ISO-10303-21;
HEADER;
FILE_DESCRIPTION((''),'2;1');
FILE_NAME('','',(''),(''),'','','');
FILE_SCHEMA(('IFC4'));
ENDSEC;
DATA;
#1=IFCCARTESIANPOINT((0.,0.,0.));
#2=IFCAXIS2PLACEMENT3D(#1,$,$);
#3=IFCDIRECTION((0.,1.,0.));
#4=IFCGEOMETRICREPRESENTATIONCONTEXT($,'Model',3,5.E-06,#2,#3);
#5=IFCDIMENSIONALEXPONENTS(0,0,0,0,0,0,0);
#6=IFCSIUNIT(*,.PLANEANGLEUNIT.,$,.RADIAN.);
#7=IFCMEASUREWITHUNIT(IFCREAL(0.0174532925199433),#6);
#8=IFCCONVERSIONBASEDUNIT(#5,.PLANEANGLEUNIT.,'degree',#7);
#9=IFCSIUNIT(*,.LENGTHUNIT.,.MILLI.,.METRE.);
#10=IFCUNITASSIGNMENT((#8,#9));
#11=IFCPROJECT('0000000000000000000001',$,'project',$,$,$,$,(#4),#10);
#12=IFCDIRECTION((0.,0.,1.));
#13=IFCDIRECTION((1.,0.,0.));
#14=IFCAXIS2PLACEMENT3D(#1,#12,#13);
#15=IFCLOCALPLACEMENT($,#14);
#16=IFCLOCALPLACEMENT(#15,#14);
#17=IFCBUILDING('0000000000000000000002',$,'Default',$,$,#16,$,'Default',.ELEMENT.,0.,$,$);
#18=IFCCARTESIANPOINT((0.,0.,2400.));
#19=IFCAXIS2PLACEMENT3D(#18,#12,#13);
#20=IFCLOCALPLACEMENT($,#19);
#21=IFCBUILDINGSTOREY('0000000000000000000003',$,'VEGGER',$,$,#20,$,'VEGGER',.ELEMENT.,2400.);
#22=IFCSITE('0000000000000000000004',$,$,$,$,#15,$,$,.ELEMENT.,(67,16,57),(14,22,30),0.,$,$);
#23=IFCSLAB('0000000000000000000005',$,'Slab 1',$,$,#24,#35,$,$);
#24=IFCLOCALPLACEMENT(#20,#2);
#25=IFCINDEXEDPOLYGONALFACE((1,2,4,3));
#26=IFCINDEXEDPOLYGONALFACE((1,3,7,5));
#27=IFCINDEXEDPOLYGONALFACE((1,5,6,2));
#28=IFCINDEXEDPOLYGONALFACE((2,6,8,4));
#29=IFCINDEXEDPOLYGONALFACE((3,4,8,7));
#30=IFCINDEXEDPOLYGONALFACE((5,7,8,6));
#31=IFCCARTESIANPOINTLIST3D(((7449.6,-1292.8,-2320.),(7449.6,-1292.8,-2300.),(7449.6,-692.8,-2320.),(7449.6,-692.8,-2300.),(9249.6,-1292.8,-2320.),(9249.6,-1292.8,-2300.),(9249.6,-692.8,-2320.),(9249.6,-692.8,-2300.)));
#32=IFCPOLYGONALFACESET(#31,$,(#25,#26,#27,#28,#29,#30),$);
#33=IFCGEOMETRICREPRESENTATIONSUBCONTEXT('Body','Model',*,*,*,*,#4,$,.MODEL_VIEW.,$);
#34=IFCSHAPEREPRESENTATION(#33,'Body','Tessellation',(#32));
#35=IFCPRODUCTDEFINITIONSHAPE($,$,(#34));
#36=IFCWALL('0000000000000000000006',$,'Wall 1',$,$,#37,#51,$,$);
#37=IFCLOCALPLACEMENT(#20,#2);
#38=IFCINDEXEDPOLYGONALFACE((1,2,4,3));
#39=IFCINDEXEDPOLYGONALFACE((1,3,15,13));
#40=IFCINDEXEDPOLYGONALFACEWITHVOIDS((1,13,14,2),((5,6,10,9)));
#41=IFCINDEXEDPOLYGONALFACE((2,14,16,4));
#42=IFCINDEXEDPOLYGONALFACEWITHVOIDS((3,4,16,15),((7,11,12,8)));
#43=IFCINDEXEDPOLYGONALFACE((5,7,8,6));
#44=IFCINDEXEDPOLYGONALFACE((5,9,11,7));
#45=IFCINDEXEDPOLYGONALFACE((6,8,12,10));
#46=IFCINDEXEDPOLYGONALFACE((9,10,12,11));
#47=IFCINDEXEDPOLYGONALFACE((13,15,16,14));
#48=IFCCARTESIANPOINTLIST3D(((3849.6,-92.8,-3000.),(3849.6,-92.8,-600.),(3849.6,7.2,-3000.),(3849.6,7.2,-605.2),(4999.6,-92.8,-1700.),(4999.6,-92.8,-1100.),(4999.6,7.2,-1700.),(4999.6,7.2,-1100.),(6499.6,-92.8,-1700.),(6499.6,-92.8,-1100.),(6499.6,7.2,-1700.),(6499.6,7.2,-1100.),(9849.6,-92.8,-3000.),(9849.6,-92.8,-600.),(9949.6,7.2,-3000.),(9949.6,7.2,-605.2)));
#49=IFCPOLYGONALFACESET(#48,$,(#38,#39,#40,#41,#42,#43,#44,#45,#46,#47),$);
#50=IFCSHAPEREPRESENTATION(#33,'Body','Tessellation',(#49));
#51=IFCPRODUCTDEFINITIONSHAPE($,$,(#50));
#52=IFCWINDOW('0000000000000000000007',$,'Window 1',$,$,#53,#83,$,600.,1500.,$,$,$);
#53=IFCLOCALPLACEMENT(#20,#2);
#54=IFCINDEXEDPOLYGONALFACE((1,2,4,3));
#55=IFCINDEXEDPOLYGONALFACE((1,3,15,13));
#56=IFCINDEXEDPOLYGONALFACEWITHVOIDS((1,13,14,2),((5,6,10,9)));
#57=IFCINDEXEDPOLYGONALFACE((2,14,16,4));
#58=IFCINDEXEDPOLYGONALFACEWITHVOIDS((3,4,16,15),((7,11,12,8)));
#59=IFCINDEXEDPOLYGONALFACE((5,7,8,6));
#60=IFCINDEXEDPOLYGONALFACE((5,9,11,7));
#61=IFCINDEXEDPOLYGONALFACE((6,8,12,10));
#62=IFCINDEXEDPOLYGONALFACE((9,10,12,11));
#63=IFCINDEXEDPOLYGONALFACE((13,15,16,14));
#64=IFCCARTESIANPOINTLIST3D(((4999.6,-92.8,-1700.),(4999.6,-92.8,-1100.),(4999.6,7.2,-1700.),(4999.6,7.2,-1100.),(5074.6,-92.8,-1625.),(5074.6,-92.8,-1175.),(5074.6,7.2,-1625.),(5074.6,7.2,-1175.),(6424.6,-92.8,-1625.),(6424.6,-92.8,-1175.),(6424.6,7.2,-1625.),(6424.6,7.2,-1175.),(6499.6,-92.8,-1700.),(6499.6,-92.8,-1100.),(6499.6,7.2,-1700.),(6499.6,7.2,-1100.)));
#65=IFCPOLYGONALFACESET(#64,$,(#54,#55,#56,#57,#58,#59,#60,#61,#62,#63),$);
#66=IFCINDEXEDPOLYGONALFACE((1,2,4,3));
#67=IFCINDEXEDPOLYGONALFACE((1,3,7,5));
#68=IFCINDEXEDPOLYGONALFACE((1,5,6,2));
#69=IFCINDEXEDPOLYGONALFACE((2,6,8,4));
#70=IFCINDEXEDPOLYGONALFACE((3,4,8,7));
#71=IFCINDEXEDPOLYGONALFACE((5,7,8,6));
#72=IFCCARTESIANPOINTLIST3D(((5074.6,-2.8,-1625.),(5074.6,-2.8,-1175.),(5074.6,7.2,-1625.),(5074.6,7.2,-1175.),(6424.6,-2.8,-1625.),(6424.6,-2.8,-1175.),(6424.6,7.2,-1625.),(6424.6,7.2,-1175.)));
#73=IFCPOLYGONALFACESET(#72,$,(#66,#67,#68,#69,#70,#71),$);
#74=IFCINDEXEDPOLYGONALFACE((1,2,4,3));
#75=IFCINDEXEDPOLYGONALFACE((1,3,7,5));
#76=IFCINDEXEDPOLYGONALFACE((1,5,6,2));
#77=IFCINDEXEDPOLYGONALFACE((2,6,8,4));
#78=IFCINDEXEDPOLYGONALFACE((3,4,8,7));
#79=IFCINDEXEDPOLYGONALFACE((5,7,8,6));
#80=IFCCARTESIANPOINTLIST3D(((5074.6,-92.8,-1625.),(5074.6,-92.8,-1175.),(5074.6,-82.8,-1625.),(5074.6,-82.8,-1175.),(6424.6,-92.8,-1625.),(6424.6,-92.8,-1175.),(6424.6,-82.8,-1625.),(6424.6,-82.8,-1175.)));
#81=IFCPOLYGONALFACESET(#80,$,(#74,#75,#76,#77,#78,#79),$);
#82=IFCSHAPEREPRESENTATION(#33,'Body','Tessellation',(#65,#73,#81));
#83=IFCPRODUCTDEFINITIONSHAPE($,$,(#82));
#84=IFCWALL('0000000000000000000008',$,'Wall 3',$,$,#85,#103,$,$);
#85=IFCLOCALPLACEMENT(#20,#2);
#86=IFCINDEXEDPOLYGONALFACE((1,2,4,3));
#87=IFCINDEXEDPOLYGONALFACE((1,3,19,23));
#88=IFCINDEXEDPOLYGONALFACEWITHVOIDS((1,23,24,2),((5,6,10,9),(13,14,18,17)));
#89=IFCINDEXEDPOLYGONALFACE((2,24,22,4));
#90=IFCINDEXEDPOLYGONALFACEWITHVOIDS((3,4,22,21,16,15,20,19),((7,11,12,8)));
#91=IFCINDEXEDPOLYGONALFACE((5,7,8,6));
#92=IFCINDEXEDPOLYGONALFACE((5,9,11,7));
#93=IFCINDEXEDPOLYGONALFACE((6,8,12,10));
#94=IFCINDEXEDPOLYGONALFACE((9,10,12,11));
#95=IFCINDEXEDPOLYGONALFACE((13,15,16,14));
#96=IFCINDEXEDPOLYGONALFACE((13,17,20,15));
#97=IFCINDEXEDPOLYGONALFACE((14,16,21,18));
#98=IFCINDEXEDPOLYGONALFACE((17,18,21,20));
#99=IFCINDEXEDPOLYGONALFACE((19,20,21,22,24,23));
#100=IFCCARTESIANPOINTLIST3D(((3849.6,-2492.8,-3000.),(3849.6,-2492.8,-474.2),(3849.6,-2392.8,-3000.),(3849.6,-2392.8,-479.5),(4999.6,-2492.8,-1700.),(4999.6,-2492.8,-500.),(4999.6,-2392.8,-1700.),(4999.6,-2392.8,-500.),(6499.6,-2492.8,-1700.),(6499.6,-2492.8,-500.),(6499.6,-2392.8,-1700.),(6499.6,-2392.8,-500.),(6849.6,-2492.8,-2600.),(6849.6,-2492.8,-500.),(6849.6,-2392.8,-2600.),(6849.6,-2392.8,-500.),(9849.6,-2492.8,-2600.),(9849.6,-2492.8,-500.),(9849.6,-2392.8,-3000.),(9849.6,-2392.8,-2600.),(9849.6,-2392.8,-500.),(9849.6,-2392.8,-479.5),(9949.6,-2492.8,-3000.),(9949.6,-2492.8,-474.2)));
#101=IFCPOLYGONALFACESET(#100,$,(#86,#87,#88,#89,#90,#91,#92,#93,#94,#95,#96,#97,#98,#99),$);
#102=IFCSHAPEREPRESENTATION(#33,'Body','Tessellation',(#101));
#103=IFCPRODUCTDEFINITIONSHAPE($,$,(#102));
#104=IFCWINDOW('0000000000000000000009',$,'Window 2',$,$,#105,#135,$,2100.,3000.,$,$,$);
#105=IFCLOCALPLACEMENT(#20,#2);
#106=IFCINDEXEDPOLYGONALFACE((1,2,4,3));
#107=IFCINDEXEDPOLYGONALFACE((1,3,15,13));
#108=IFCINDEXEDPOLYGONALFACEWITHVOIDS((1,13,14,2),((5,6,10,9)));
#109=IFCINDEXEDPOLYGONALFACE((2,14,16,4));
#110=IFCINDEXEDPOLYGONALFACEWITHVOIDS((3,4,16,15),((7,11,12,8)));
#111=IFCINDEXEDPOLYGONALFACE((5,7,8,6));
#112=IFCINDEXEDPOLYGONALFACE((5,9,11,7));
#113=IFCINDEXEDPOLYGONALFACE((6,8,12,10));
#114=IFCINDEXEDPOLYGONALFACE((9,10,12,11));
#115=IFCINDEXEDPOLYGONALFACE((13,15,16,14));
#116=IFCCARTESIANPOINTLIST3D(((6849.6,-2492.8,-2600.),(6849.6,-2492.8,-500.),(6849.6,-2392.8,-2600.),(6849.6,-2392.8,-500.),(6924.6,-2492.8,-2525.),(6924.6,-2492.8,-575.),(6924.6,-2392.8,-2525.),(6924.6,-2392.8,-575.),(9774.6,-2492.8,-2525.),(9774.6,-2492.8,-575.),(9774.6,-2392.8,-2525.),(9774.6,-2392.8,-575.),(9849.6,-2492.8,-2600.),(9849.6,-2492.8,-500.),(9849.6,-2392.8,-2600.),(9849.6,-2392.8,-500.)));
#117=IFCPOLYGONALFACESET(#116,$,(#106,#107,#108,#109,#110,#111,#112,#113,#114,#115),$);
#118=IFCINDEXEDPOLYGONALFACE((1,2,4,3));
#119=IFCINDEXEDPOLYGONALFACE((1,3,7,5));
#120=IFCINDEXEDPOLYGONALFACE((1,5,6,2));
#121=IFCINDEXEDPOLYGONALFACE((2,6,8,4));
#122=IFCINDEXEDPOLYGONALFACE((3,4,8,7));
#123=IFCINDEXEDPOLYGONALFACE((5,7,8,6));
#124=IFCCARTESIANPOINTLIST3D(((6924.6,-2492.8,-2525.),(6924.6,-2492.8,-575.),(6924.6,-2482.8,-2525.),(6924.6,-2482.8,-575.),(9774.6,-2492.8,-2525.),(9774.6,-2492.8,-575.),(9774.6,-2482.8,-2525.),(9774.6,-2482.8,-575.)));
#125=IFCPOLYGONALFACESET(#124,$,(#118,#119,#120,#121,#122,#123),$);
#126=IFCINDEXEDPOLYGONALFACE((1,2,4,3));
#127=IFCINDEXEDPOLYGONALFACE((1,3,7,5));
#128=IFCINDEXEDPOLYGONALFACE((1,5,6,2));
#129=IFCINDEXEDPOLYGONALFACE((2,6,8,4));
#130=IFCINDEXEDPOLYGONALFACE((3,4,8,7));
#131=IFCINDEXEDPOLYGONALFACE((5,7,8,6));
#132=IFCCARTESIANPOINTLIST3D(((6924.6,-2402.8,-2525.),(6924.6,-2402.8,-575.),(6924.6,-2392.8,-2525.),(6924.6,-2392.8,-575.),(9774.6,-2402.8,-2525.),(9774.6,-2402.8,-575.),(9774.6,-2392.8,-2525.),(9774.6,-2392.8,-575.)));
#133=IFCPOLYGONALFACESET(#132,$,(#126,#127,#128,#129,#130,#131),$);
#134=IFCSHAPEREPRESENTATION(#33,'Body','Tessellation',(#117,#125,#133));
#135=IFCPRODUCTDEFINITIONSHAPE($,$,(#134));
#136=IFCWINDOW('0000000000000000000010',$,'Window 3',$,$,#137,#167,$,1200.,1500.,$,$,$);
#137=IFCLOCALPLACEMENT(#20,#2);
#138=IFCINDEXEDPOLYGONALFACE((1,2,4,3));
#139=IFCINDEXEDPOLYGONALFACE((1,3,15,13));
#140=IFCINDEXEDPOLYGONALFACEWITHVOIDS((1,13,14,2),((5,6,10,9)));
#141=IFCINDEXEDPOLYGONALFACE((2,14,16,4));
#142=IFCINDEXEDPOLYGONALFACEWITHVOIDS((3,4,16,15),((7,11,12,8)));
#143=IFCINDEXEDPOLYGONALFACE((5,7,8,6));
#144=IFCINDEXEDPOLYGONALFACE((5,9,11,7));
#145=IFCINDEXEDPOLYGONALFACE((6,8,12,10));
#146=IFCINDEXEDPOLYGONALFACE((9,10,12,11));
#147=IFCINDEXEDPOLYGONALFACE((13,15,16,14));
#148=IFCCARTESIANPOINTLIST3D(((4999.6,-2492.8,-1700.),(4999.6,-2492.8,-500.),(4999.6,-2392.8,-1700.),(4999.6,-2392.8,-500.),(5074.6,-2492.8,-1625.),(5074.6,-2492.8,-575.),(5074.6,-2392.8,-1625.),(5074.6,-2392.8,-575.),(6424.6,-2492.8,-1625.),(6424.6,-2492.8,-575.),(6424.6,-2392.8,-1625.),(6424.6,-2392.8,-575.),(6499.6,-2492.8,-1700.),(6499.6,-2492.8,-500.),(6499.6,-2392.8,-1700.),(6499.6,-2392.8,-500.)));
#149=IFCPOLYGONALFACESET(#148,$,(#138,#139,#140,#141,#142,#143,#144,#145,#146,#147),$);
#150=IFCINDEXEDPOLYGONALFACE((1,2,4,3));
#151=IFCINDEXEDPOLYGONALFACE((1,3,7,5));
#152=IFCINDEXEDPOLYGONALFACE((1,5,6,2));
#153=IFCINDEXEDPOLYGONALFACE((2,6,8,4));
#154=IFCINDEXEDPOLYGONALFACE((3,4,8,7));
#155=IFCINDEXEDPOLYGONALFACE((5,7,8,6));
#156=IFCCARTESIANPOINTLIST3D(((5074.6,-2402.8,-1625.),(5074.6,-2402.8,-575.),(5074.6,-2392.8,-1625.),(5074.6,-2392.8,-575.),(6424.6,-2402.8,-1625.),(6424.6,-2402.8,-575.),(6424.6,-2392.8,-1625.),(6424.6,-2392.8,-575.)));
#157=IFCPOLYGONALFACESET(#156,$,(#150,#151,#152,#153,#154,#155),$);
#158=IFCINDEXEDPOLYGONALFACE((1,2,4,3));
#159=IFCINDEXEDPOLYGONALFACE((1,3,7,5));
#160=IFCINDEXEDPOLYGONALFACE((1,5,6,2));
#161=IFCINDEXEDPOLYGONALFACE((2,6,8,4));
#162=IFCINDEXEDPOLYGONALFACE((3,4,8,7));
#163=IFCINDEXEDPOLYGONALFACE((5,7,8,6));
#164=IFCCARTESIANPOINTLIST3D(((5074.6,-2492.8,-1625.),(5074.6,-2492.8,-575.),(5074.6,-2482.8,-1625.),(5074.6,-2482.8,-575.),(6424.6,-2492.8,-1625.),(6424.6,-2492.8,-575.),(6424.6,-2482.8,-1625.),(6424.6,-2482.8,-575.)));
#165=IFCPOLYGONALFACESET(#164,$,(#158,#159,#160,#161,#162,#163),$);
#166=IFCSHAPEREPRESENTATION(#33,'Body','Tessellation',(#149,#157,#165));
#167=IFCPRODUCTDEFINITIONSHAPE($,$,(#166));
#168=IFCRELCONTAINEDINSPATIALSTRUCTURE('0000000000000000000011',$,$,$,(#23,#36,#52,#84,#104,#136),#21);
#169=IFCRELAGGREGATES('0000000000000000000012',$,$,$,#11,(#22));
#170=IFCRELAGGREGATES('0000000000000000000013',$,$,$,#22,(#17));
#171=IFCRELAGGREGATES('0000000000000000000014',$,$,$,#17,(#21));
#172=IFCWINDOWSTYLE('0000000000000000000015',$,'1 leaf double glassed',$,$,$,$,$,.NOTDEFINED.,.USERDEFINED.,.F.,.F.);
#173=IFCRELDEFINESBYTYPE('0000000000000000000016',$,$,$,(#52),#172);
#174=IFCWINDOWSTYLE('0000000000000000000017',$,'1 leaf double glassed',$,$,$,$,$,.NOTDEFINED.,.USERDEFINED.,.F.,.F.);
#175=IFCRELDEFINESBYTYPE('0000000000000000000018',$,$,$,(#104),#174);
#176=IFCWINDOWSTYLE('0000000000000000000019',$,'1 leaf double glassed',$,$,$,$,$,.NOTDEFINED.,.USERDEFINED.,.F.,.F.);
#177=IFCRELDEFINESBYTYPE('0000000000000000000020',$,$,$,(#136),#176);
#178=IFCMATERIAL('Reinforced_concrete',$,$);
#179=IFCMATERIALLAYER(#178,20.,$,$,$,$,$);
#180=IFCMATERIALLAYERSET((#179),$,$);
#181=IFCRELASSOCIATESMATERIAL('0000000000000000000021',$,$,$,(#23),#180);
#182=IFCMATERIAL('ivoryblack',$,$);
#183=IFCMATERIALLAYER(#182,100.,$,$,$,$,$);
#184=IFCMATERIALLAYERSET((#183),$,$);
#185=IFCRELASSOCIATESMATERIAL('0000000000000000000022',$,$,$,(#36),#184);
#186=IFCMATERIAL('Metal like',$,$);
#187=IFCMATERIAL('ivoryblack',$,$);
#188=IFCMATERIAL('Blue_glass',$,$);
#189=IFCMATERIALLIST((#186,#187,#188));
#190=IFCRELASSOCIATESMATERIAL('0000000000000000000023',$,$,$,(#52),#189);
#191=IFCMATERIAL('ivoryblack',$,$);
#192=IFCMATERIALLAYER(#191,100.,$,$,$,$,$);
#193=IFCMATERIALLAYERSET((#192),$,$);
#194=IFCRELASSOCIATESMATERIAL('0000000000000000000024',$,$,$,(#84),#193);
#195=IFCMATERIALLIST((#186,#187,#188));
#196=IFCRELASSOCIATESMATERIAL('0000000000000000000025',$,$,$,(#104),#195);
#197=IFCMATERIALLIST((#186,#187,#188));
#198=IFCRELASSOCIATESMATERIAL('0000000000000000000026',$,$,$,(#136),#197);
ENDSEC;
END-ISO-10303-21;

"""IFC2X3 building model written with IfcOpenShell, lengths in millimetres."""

from ifc_helpers import new_model, entity, si_unit, converted_unit, direction, frame, origin, origin_with_axes, place, context, subcontext, project, spatial, polyline, outline, extrude, boolean, material, material_list, layer, layer_set, layer_usage, type_object, element, fill, save


model = new_model("IFC2X3")

# Units and contexts
model_context = context("Model", 3, precision=5e-06, world=origin(), true_north=direction((0.0, 1.0, 0.0)))
body_context = subcontext(model_context, "Body", "Model", "MODEL_VIEW")
ifc_project = project(units=[converted_unit("PLANEANGLEUNIT", "degree", entity("IfcReal", 0.0174532925199433), si_unit("PLANEANGLEUNIT", "RADIAN"), dimensions=[0, 0, 0, 0, 0, 0, 0]), si_unit("LENGTHUNIT", "METRE", prefix="MILLI")], contexts=[model_context])

# Site, building, storey
site_placement = place(None, origin_with_axes())
site = spatial("IfcSite", under=ifc_project, at=site_placement, CompositionType="ELEMENT", RefLatitude=(67, 16, 57), RefLongitude=(14, 22, 30), RefElevation=0.0)
building_placement = place(site_placement, origin_with_axes())
building = spatial("IfcBuilding", under=site, at=building_placement, Name="Default", LongName="Default", CompositionType="ELEMENT", ElevationOfRefHeight=0.0)
storey_placement = place(None, frame((0.0, 0.0, 2400.0), z_axis=(0.0, 0.0, 1.0), x_axis=(1.0, 0.0, 0.0)))
storey = spatial("IfcBuildingStorey", under=building, at=storey_placement, Name="VEGGER", LongName="VEGGER", CompositionType="ELEMENT", Elevation=2400.0)

# Slab
ifc_material_1 = material(Name="Reinforced_concrete")
ifc_layer_1 = layer(ifc_material_1, 20.0)
ifc_layer_set_1 = layer_set([ifc_layer_1])
ifc_layer_usage = layer_usage(ifc_layer_set_1, "AXIS3", "NEGATIVE", 0.0)
slab_placement = place(storey_placement, frame((8349.6, -992.8, -2320.0), z_axis=(0.0, 0.0, 1.0), x_axis=(1.0, 0.0, 0.0)))
element("IfcSlab", 1, at=slab_placement, inside=storey, material=ifc_layer_usage, Name="Slab 1", context=body_context, shape_type="SweptSolid", body=[
    extrude(outline(polyline([(9249.6, -692.8), (7449.6, -692.8), (7449.6, -1292.8), (9249.6, -1292.8), (9249.6, -692.8)])), frame((-8349.6, 992.8, 0.0), z_axis=(0.0, 0.0, 1.0), x_axis=(1.0, 0.0, 0.0)), (0.0, 0.0, 1.0), 20.0),
])

# Wall, opening, window
ifc_material_2 = material(Name="ivoryblack")
ifc_layer_2 = layer(ifc_material_2, 100.0)
ifc_layer_set_2 = layer_set([ifc_layer_2])
wall_1_placement = place(storey_placement, frame((3849.6, 7.2, -3000.0), z_axis=(0.0, 0.0, 1.0), x_axis=(1.0, 0.0, 0.0)))
wall_1 = element("IfcWall", 2, at=wall_1_placement, inside=storey, material=ifc_layer_set_2, Name="Wall 1", context=body_context, shape_type="CSG", body=[
    boolean("DIFFERENCE", extrude(outline(polyline([(9949.6, 7.2), (3849.6, 7.2), (3849.6, -92.8), (9849.6, -92.8), (9949.6, 7.2)])), frame((-3849.6, -7.2, 0.0), z_axis=(0.0, 0.0, 1.0), x_axis=(1.0, 0.0, 0.0)), (0.0, 0.0, 1.0), 6000.0), extrude(outline(polyline([(9999.6, -2546.3), (9999.6, 57.3), (3799.6, 57.3), (3799.6, -2546.3), (9999.6, -2546.3)])), frame((-3849.6, -7.2, 2395.1), z_axis=(0.0, 0.052336, 0.99863), x_axis=(1.0, 0.0, 0.0)), (0.0, -0.052336, 0.99863), 10000000.0)),
])
opening_1_placement = place(wall_1_placement, frame((1150.0, -100.0, 1300.0), z_axis=(0.0, 0.0, 1.0), x_axis=(1.0, 0.0, 0.0)))
opening_1 = element("IfcOpeningElement", 3, at=opening_1_placement, cuts=wall_1, context=body_context, shape_type="SweptSolid", body=[
    extrude(outline(polyline([(0.0, 0.0), (1500.0, 0.0), (1500.0, 600.0), (0.0, 600.0), (0.0, 0.0)])), frame((0.0, 100.5, 0.0), z_axis=(0.0, -1.0, 0.0), x_axis=(1.0, 0.0, 0.0)), (0.0, 0.0, 1.0), 101.0),
])
ifc_material_3 = material(Name="Metal like")
ifc_material_4 = material(Name="ivoryblack")
ifc_material_5 = material(Name="Blue_glass")
ifc_material_list_1 = material_list([ifc_material_3, ifc_material_4, ifc_material_5])
window_style_1 = type_object("IfcWindowStyle", Name="1 leaf double glassed", ConstructionType="NOTDEFINED", OperationType="USERDEFINED", ParameterTakesPrecedence=False, Sizeable=False)
window_1_placement = place(opening_1_placement, frame((0.0, 0.0, 0.0), z_axis=(0.0, 0.0, 1.0), x_axis=(1.0, 0.0, 0.0)))
window_1 = element("IfcWindow", 4, at=window_1_placement, inside=storey, type_object=window_style_1, material=ifc_material_list_1, Name="Window 1", OverallHeight=600.0, OverallWidth=1500.0, context=body_context, shape_type="SweptSolid", body=[
    extrude(outline(polyline([(0.0, 0.0), (1500.0, 0.0), (1500.0, 600.0), (0.0, 600.0), (0.0, 0.0)]), holes=[polyline([(75.0, 75.0), (75.0, 525.0), (1425.0, 525.0), (1425.0, 75.0), (75.0, 75.0)])]), frame((0.0, 100.0, 0.0), z_axis=(0.0, -1.0, 0.0), x_axis=(1.0, 0.0, 0.0)), (0.0, 0.0, 1.0), 100.0),
    extrude(outline(polyline([(75.0, 75.0), (1425.0, 75.0), (1425.0, 525.0), (75.0, 525.0), (75.0, 75.0)])), frame((0.0, 100.0, 0.0), z_axis=(0.0, -1.0, 0.0), x_axis=(1.0, 0.0, 0.0)), (0.0, 0.0, 1.0), 10.0),
    extrude(outline(polyline([(75.0, 75.0), (1425.0, 75.0), (1425.0, 525.0), (75.0, 525.0), (75.0, 75.0)])), frame((0.0, 10.0, 0.0), z_axis=(0.0, -1.0, 0.0), x_axis=(1.0, 0.0, 0.0)), (0.0, 0.0, 1.0), 10.0),
])
fill(opening_1, window_1)

# Wall, openings, windows
ifc_material_6 = material(Name="ivoryblack")
ifc_layer_3 = layer(ifc_material_6, 100.0)
ifc_layer_set_3 = layer_set([ifc_layer_3])
wall_2_placement = place(storey_placement, frame((9949.6, -2492.8, -3000.0), z_axis=(0.0, 0.0, 1.0), x_axis=(-1.0, 0.0, 0.0)))
wall_2 = element("IfcWall", 5, at=wall_2_placement, inside=storey, material=ifc_layer_set_3, Name="Wall 3", context=body_context, shape_type="CSG", body=[
    boolean("DIFFERENCE", extrude(outline(polyline([(3849.6, -2492.8), (9949.6, -2492.8), (9849.6, -2392.8), (3849.6, -2392.8), (3849.6, -2492.8)])), frame((9949.6, -2492.8, 0.0), z_axis=(0.0, 0.0, 1.0), x_axis=(-1.0, 0.0, 0.0)), (0.0, 0.0, 1.0), 6000.0), extrude(outline(polyline([(9999.6, -2546.3), (9999.6, 57.3), (3799.6, 57.3), (3799.6, -2546.3), (9999.6, -2546.3)])), frame((9949.6, -2492.8, 2395.1), z_axis=(0.0, -0.052336, 0.99863), x_axis=(-1.0, 0.0, 0.0)), (0.0, -0.052336, 0.99863), 10000000.0)),
])
opening_2_placement = place(wall_2_placement, frame((100.0, -100.0, 400.0), z_axis=(0.0, 0.0, 1.0), x_axis=(1.0, 0.0, 0.0)))
opening_2 = element("IfcOpeningElement", 6, at=opening_2_placement, cuts=wall_2, context=body_context, shape_type="SweptSolid", body=[
    extrude(outline(polyline([(0.0, 0.0), (3000.0, 0.0), (3000.0, 2100.0), (0.0, 2100.0), (0.0, 0.0)])), frame((0.0, 100.5, 0.0), z_axis=(0.0, -1.0, 0.0), x_axis=(1.0, 0.0, 0.0)), (0.0, 0.0, 1.0), 101.0),
])
opening_3_placement = place(wall_2_placement, frame((4950.0, 0.0, 1300.0), z_axis=(0.0, 0.0, 1.0), x_axis=(-1.0, 0.0, 0.0)))
opening_3 = element("IfcOpeningElement", 7, at=opening_3_placement, cuts=wall_2, context=body_context, shape_type="SweptSolid", body=[
    extrude(outline(polyline([(0.0, 0.0), (1500.0, 0.0), (1500.0, 1200.0), (0.0, 1200.0), (0.0, 0.0)])), frame((0.0, 100.5, 0.0), z_axis=(0.0, -1.0, 0.0), x_axis=(1.0, 0.0, 0.0)), (0.0, 0.0, 1.0), 101.0),
])
ifc_material_list_2 = material_list([ifc_material_3, ifc_material_4, ifc_material_5])
window_style_2 = type_object("IfcWindowStyle", Name="1 leaf double glassed", ConstructionType="NOTDEFINED", OperationType="USERDEFINED", ParameterTakesPrecedence=False, Sizeable=False)
window_2_placement = place(opening_2_placement, origin_with_axes())
window_2 = element("IfcWindow", 8, at=window_2_placement, inside=storey, type_object=window_style_2, material=ifc_material_list_2, Name="Window 2", OverallHeight=2100.0, OverallWidth=3000.0, context=body_context, shape_type="SweptSolid", body=[
    extrude(outline(polyline([(0.0, 0.0), (3000.0, 0.0), (3000.0, 2100.0), (0.0, 2100.0), (0.0, 0.0)]), holes=[polyline([(75.0, 75.0), (75.0, 2025.0), (2925.0, 2025.0), (2925.0, 75.0), (75.0, 75.0)])]), frame((0.0, 100.0, 0.0), z_axis=(0.0, -1.0, 0.0), x_axis=(1.0, 0.0, 0.0)), (0.0, 0.0, 1.0), 100.0),
    extrude(outline(polyline([(75.0, 75.0), (2925.0, 75.0), (2925.0, 2025.0), (75.0, 2025.0), (75.0, 75.0)])), frame((0.0, 100.0, 0.0), z_axis=(0.0, -1.0, 0.0), x_axis=(1.0, 0.0, 0.0)), (0.0, 0.0, 1.0), 10.0),
    extrude(outline(polyline([(75.0, 75.0), (2925.0, 75.0), (2925.0, 2025.0), (75.0, 2025.0), (75.0, 75.0)])), frame((0.0, 10.0, 0.0), z_axis=(0.0, -1.0, 0.0), x_axis=(1.0, 0.0, 0.0)), (0.0, 0.0, 1.0), 10.0),
])
fill(opening_2, window_2)
ifc_material_list_3 = material_list([ifc_material_3, ifc_material_4, ifc_material_5])
window_style_3 = type_object("IfcWindowStyle", Name="1 leaf double glassed", ConstructionType="NOTDEFINED", OperationType="USERDEFINED", ParameterTakesPrecedence=False, Sizeable=False)
window_3_placement = place(opening_3_placement, origin_with_axes())
window_3 = element("IfcWindow", 9, at=window_3_placement, inside=storey, type_object=window_style_3, material=ifc_material_list_3, Name="Window 3", OverallHeight=1200.0, OverallWidth=1500.0, context=body_context, shape_type="SweptSolid", body=[
    extrude(outline(polyline([(0.0, 0.0), (1500.0, 0.0), (1500.0, 1200.0), (0.0, 1200.0), (0.0, 0.0)]), holes=[polyline([(75.0, 75.0), (75.0, 1125.0), (1425.0, 1125.0), (1425.0, 75.0), (75.0, 75.0)])]), frame((0.0, 100.0, 0.0), z_axis=(0.0, -1.0, 0.0), x_axis=(1.0, 0.0, 0.0)), (0.0, 0.0, 1.0), 100.0),
    extrude(outline(polyline([(75.0, 75.0), (1425.0, 75.0), (1425.0, 1125.0), (75.0, 1125.0), (75.0, 75.0)])), frame((0.0, 100.0, 0.0), z_axis=(0.0, -1.0, 0.0), x_axis=(1.0, 0.0, 0.0)), (0.0, 0.0, 1.0), 10.0),
    extrude(outline(polyline([(75.0, 75.0), (1425.0, 75.0), (1425.0, 1125.0), (75.0, 1125.0), (75.0, 75.0)])), frame((0.0, 10.0, 0.0), z_axis=(0.0, -1.0, 0.0), x_axis=(1.0, 0.0, 0.0)), (0.0, 0.0, 1.0), 10.0),
])
fill(opening_3, window_3)

save(model, "model.ifc")
